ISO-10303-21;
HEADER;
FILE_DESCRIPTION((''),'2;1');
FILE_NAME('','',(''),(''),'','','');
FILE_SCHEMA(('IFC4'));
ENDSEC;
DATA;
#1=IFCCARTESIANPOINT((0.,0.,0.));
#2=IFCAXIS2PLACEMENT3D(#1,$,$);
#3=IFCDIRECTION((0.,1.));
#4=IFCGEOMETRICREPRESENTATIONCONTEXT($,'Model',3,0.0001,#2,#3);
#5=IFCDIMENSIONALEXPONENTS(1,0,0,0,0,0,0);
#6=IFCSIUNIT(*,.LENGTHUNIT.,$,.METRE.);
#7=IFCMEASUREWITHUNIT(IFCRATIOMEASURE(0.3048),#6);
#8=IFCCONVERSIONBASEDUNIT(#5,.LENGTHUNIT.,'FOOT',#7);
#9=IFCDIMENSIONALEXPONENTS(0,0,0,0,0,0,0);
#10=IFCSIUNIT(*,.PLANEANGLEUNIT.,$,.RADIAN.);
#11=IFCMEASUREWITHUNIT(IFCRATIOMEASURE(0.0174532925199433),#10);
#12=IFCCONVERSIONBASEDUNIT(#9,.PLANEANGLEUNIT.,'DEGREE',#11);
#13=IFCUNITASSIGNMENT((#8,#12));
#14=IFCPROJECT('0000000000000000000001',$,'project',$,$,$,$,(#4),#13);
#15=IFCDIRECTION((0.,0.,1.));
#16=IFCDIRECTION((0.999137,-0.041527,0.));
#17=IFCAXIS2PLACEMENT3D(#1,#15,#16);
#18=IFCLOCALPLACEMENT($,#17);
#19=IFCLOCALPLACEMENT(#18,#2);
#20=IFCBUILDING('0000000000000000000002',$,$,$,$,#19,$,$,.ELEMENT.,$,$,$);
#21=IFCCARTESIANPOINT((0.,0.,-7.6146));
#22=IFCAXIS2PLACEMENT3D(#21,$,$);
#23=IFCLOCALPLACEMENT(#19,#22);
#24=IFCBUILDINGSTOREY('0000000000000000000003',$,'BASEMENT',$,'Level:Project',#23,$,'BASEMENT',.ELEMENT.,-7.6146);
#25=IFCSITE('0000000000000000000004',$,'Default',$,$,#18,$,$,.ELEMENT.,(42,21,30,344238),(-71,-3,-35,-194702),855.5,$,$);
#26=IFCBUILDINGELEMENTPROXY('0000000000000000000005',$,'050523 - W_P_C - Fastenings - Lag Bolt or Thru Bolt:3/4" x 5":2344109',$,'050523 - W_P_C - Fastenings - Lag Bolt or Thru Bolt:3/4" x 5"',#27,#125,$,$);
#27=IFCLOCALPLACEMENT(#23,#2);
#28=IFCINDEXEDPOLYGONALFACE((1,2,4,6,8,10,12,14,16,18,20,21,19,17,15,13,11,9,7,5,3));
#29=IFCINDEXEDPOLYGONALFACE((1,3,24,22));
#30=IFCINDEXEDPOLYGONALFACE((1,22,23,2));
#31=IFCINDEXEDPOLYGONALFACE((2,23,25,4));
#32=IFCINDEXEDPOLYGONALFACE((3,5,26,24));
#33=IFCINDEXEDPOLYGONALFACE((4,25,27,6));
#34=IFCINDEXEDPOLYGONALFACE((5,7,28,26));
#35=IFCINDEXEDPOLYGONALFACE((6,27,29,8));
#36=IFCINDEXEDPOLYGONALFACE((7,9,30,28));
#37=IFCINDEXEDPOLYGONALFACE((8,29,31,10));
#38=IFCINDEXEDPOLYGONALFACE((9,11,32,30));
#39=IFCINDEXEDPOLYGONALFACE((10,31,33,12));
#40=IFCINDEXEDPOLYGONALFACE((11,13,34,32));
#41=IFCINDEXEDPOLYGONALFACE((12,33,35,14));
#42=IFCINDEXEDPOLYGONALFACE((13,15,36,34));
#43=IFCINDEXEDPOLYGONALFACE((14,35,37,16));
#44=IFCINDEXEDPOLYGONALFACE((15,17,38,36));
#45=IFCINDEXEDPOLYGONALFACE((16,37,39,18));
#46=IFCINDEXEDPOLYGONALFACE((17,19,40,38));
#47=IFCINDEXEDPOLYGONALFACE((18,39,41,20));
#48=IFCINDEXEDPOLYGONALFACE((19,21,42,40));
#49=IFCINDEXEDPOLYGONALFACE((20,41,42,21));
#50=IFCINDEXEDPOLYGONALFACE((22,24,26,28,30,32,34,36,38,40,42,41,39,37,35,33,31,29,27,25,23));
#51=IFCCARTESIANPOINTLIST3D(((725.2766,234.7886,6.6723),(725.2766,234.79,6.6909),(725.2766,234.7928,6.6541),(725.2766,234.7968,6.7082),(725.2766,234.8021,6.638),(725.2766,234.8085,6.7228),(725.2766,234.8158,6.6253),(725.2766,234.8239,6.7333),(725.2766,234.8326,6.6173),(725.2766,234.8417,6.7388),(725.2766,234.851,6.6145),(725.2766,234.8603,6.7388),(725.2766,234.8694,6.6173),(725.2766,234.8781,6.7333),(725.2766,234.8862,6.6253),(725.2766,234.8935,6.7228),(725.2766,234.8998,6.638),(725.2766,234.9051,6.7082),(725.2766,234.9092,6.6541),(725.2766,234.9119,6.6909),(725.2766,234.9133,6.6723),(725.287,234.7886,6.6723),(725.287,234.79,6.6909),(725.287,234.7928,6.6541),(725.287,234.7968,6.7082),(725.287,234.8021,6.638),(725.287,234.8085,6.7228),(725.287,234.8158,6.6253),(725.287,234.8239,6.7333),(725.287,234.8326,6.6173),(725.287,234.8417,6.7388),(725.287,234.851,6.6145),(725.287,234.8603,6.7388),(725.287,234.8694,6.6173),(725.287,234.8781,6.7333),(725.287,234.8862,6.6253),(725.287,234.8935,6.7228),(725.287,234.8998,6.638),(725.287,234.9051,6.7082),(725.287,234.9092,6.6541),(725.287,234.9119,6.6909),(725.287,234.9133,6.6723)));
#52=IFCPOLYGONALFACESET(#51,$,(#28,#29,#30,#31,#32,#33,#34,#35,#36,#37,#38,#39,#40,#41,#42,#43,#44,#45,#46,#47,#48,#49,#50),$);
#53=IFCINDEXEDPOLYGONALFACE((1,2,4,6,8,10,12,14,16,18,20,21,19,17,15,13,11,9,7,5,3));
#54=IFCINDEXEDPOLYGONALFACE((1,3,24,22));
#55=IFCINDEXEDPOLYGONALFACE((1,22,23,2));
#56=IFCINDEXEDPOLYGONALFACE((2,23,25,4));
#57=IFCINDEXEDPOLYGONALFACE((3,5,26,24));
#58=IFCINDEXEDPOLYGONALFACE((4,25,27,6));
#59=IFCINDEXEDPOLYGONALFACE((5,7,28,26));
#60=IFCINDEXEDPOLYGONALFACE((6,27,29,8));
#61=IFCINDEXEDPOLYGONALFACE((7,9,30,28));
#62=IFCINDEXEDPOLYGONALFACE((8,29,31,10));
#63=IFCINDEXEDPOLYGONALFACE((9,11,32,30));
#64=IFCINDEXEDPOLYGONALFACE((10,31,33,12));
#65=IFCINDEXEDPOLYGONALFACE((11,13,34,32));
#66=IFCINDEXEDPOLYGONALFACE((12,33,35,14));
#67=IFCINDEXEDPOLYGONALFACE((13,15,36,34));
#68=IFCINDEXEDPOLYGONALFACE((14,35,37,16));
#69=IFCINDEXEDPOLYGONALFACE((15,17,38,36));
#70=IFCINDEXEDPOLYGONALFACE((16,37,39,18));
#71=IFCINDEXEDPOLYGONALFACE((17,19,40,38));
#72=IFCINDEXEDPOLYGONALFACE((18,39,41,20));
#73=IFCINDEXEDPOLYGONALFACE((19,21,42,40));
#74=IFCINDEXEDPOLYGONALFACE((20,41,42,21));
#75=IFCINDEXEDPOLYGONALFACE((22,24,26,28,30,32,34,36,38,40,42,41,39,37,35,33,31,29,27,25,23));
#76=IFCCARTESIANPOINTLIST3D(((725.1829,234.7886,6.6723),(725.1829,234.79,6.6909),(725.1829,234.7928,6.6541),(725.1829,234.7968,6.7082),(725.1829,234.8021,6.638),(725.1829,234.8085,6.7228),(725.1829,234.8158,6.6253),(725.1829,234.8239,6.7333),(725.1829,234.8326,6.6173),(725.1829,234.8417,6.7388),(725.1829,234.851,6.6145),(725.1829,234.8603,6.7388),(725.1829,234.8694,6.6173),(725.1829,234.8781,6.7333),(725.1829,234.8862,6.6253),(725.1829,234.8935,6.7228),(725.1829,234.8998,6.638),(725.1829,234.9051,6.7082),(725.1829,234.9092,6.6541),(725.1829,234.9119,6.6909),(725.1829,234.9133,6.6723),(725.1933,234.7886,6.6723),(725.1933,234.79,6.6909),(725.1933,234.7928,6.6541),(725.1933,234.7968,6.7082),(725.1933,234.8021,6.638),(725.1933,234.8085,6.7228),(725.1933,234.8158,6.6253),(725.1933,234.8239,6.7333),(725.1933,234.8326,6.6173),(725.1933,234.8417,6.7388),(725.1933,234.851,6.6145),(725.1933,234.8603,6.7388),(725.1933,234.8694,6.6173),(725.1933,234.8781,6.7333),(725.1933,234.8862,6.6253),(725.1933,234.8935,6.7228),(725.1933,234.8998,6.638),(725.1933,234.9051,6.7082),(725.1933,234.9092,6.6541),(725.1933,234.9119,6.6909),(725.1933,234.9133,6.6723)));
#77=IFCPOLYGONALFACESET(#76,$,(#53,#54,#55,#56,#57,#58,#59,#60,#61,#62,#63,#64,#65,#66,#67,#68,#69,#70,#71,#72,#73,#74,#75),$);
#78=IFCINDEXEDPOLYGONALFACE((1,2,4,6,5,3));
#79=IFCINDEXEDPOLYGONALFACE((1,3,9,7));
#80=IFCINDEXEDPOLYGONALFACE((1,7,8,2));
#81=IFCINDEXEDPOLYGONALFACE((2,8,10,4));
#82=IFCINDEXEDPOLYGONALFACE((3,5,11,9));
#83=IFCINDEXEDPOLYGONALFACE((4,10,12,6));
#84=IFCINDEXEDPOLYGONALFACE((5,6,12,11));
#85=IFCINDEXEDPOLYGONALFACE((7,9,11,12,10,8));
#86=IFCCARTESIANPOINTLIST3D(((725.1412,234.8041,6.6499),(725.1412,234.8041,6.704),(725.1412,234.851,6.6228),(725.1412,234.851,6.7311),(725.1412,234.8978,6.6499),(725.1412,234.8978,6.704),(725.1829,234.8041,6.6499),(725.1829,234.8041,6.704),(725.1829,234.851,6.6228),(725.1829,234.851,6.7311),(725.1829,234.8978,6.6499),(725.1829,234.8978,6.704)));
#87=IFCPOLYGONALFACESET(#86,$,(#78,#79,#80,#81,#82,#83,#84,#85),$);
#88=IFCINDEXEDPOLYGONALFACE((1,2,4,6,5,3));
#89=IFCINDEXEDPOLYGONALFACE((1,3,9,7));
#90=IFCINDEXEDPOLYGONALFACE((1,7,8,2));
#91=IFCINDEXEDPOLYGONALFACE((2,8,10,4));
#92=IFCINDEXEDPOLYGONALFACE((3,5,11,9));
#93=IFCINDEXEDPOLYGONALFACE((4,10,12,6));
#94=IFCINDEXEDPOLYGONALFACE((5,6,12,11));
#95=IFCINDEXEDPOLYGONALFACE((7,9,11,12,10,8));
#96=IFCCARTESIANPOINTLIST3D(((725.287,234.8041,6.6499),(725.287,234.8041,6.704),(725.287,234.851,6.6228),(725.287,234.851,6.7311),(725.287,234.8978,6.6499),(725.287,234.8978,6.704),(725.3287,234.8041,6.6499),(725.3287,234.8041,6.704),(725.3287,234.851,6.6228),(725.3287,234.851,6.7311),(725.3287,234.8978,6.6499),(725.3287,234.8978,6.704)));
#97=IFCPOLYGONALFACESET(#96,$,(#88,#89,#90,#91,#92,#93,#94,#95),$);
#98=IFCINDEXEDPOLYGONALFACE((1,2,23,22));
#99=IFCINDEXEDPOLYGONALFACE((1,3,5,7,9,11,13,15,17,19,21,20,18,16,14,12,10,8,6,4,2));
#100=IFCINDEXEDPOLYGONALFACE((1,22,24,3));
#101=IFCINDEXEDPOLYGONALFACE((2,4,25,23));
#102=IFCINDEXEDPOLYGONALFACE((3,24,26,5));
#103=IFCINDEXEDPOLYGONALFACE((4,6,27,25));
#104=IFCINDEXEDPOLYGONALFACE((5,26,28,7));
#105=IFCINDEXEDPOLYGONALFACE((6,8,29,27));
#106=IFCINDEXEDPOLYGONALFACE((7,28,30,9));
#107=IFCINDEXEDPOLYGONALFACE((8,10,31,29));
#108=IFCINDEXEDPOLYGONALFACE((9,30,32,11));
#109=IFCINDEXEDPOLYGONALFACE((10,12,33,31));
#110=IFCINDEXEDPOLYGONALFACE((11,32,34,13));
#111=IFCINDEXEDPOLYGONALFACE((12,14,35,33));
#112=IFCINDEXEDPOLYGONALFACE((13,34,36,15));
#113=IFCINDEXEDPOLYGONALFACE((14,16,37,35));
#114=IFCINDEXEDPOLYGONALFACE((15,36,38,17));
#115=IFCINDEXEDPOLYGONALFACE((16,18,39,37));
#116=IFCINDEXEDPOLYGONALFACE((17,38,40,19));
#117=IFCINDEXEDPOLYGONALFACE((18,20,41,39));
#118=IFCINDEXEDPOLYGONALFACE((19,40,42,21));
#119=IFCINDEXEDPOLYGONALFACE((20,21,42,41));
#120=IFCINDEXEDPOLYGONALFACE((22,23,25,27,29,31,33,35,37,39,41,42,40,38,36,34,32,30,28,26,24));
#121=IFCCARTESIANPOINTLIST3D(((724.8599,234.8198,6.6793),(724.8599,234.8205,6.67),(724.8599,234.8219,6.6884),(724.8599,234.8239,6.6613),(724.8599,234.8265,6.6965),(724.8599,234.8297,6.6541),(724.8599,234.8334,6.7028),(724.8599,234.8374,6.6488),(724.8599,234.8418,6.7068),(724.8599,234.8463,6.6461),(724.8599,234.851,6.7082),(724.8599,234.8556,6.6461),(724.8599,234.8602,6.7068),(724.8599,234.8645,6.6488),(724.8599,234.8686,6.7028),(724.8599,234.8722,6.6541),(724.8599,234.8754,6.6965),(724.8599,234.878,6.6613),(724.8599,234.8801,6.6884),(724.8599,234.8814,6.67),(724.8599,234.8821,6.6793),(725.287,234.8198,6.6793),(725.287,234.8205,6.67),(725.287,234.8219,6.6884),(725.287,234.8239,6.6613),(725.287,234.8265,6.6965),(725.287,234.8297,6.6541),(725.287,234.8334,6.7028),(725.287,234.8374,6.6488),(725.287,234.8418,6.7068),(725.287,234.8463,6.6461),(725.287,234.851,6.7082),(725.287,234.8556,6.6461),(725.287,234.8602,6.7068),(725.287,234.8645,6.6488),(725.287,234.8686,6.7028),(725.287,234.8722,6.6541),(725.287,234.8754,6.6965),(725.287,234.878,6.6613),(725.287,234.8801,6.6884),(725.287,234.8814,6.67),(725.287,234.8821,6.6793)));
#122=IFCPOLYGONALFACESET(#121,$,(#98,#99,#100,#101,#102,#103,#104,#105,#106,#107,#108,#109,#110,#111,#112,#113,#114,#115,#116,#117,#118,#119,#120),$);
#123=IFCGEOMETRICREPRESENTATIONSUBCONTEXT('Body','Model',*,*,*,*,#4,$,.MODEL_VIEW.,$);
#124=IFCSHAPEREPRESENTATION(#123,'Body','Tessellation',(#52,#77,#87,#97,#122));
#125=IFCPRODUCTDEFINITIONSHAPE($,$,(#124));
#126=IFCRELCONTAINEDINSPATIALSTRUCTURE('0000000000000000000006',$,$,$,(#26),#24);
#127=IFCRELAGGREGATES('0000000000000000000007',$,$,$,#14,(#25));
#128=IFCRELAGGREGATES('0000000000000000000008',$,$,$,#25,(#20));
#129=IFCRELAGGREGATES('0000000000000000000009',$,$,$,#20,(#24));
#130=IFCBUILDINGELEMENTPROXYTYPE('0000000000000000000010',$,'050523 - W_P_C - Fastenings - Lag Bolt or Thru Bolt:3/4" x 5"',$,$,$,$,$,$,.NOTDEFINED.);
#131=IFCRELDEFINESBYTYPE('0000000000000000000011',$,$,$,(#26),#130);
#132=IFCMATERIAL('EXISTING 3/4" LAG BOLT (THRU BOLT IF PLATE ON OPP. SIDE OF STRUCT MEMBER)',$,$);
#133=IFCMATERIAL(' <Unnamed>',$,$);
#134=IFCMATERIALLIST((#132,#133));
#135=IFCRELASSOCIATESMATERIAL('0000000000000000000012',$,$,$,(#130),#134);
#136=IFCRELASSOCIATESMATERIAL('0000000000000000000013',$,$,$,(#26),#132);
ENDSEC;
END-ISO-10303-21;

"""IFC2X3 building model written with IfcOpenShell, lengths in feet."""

from ifc_helpers import new_model, entity, si_unit, converted_unit, direction, frame, frame_2d, origin, place, context, subcontext, project, spatial, polyline, circle, outline, extrude, source, transform, mapped, material, material_list, type_object, type_shapes, element, save


model = new_model("IFC2X3")

# Units and contexts
model_context = context("Model", 3, precision=0.0001, world=origin(), true_north=direction((0.0, 1.0)))
body_context = subcontext(model_context, "Body", "Model", "MODEL_VIEW")
ifc_project = project(units=[converted_unit("LENGTHUNIT", "FOOT", entity("IfcRatioMeasure", 0.3048), si_unit("LENGTHUNIT", "METRE"), dimensions=[1, 0, 0, 0, 0, 0, 0]), converted_unit("PLANEANGLEUNIT", "DEGREE", entity("IfcRatioMeasure", 0.0174532925199433), si_unit("PLANEANGLEUNIT", "RADIAN"), dimensions=[0, 0, 0, 0, 0, 0, 0])], contexts=[model_context])

# Site, building, storey
site_placement = place(None, frame((0.0, 0.0, 0.0), z_axis=(0.0, 0.0, 1.0), x_axis=(0.999137, -0.041527, 0.0)))
site = spatial("IfcSite", under=ifc_project, at=site_placement, Name="Default", CompositionType="ELEMENT", RefLatitude=(42, 21, 30, 344238), RefLongitude=(-71, -3, -35, -194702), RefElevation=855.5)
building_placement = place(site_placement, origin())
building = spatial("IfcBuilding", under=site, at=building_placement, CompositionType="ELEMENT")
storey_placement = place(building_placement, frame((0.0, 0.0, -7.6146)))
storey = spatial("IfcBuildingStorey", under=building, at=storey_placement, Name="BASEMENT", ObjectType="Level:Project", LongName="BASEMENT", CompositionType="ELEMENT", Elevation=-7.6146)

# Building element proxy
ifc_material_1 = material(Name=" <Unnamed>")
ifc_material_2 = material(Name="EXISTING 3/4\" LAG BOLT (THRU BOLT IF PLATE ON OPP. SIDE OF STRUCT MEMBER)")
ifc_material_list_1 = material_list([ifc_material_2, ifc_material_1])
building_element_proxy_type_1 = type_object("IfcBuildingElementProxyType", Name="050523 - W_P_C - Fastenings - Lag Bolt or Thru Bolt:3/4\" x 5\"", PredefinedType="NOTDEFINED", material=ifc_material_list_1)
shared_shape_1 = source(origin(), body_context, "Body", "SweptSolid", [
    extrude(circle(Radius=0.0625, at=frame_2d((0.0, 0.0), x_axis=(1.0, 0.0))), frame((0.0, 0.0, 0.0), z_axis=(0.0, 0.0, 1.0), x_axis=(0.0, 1.0, 0.0)), (0.0, 0.0, 1.0), 0.0104),
    extrude(circle(Radius=0.0625, at=frame_2d((0.0, 0.0), x_axis=(1.0, 0.0))), frame((0.0, 0.0, -0.0938), z_axis=(0.0, 0.0, 1.0), x_axis=(0.0, 1.0, 0.0)), (0.0, 0.0, 1.0), 0.0104),
    extrude(outline(polyline([(-0.0271, -0.0469), (0.0271, -0.0469), (0.0541, 0.0), (0.0271, 0.0469), (-0.0271, 0.0469), (-0.0541, 0.0), (-0.0271, -0.0469)])), frame((0.0, 0.0, -0.1354), z_axis=(0.0, 0.0, 1.0), x_axis=(0.0, -1.0, 0.0)), (0.0, 0.0, 1.0), 0.0417),
    extrude(outline(polyline([(-0.0271, -0.0469), (0.0271, -0.0469), (0.0541, 0.0), (0.0271, 0.0469), (-0.0271, 0.0469), (-0.0541, 0.0), (-0.0271, -0.0469)])), frame((0.0, 0.0, 0.0104), z_axis=(0.0, 0.0, 1.0), x_axis=(0.866025, -0.5, 0.0)), (0.0, 0.0, 1.0), 0.0417),
    extrude(circle(Radius=0.0312, at=frame_2d((0.0, 0.0), x_axis=(1.0, 0.0))), frame((0.0, 0.0, -0.4167), z_axis=(0.0, 0.0, 1.0), x_axis=(0.0, -1.0, 0.0)), (0.0, 0.0, 1.0), 0.4271),
])
type_shapes(building_element_proxy_type_1, [shared_shape_1])
for number, where, z_axis, x_axis, name in (
    (1, (725.2766, 234.851, 6.677), (1.0, 0.0, 0.0), (0.0, -1.0, 0.0), "050523 - W_P_C - Fastenings - Lag Bolt or Thru Bolt:3/4\" x 5\":2344109"),
):
    element("IfcBuildingElementProxy", number, at=place(storey_placement, frame(where, z_axis=z_axis, x_axis=x_axis)), inside=storey, type_object=building_element_proxy_type_1, material=ifc_material_2, Name=name, ObjectType="050523 - W_P_C - Fastenings - Lag Bolt or Thru Bolt:3/4\" x 5\"", context=body_context, shape_type="MappedRepresentation", body=[
        mapped(shared_shape_1, transform((0.0, 0.0, 0.0), scale=1.0)),
    ])

save(model, "model.ifc")
